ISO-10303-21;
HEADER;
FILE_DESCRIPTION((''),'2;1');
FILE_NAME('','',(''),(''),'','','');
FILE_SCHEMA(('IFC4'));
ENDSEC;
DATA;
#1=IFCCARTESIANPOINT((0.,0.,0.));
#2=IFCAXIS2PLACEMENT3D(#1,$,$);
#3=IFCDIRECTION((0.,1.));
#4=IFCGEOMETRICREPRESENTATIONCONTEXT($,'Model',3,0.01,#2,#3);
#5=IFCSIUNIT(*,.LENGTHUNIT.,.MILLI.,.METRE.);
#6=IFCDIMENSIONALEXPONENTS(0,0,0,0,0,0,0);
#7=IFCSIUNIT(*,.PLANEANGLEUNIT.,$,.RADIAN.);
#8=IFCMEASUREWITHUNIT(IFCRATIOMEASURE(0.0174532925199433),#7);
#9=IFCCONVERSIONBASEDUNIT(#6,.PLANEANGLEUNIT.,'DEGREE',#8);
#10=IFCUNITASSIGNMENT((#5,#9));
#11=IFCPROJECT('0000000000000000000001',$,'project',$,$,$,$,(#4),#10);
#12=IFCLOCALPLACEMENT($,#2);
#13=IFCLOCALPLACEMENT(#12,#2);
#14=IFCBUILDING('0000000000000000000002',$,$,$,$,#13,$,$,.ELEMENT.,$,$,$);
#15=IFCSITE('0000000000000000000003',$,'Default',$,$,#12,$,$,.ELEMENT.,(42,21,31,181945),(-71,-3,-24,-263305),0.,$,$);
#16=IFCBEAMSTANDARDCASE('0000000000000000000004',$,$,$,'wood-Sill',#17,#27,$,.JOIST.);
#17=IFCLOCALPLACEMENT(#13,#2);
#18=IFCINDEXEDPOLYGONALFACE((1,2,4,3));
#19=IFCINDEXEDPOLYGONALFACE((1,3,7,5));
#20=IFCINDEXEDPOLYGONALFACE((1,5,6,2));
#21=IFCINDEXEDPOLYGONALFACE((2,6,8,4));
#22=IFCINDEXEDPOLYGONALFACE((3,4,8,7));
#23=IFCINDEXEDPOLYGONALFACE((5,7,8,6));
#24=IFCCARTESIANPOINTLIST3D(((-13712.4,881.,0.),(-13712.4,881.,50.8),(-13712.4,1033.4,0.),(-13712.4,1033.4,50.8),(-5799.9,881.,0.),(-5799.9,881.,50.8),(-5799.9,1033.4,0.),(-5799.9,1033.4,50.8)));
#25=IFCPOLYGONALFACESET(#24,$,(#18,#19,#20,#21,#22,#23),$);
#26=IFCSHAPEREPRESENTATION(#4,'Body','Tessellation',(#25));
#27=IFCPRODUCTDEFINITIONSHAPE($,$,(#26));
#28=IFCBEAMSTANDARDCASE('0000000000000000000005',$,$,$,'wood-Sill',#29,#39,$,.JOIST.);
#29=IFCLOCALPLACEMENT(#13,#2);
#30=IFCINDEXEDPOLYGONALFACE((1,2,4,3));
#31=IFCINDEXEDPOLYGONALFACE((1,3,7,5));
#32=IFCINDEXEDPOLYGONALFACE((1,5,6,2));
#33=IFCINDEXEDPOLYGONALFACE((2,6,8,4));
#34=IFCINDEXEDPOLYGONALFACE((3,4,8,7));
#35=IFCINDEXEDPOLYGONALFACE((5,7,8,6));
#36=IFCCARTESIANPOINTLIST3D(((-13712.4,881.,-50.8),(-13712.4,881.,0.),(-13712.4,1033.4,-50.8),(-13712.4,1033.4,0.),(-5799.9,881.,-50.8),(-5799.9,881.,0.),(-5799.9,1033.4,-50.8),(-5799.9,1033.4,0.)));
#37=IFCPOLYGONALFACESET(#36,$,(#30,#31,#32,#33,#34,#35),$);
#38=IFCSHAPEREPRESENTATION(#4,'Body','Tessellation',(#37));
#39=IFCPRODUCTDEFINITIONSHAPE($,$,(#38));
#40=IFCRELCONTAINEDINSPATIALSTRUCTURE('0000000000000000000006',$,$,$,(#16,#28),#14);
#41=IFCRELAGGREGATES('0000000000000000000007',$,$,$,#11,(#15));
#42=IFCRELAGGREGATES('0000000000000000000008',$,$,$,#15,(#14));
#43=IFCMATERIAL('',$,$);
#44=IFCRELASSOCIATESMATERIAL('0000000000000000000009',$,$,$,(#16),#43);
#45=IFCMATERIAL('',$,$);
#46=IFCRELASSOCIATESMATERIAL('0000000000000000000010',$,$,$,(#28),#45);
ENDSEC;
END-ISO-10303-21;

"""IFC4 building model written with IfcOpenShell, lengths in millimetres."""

from ifc_helpers import new_model, entity, si_unit, converted_unit, direction, frame, origin, place, context, project, spatial, rectangle, extrude, material, element, save


model = new_model("IFC4")

# Units and contexts
model_context = context("Model", 3, precision=0.01, world=origin(), true_north=direction((0.0, 1.0)))
ifc_project = project(units=[si_unit("LENGTHUNIT", "METRE", prefix="MILLI"), converted_unit("PLANEANGLEUNIT", "DEGREE", entity("IfcRatioMeasure", 0.0174532925199433), si_unit("PLANEANGLEUNIT", "RADIAN"), dimensions=[0, 0, 0, 0, 0, 0, 0])], contexts=[model_context])

# Site, building
site_placement = place(None, origin())
site = spatial("IfcSite", under=ifc_project, at=site_placement, Name="Default", CompositionType="ELEMENT", RefLatitude=(42, 21, 31, 181945), RefLongitude=(-71, -3, -24, -263305), RefElevation=0.0)
building_placement = place(site_placement, origin())
building = spatial("IfcBuilding", under=site, at=building_placement, CompositionType="ELEMENT")

# Shared definitions
placement_1 = place(building_placement, origin())
placement_2 = place(placement_1, frame((-5799.9, 957.2, 0.0), z_axis=(0.0, 0.0, 1.0), x_axis=(-1.0, 0.0, 0.0)))

# Beams
ifc_material_1 = material(Name="")
beam_1_placement = place(placement_2, frame((3956.2, 0.0, 0.0), z_axis=(0.0, 0.0, 1.0), x_axis=(-1.0, 0.0, 0.0)))
element("IfcBeamStandardCase", 1, at=beam_1_placement, inside=building, material=ifc_material_1, ObjectType="wood-Sill", PredefinedType="JOIST", context=model_context, shape_type="SweptSolid", body=[
    extrude(rectangle(XDim=7912.5, YDim=152.4), origin(), (0.0, 0.0, 1.0), 50.8),
])
ifc_material_2 = material(Name="")
beam_2_placement = place(placement_2, frame((3956.2, 0.0, -50.8), z_axis=(0.0, 0.0, 1.0), x_axis=(-1.0, 0.0, 0.0)))
element("IfcBeamStandardCase", 2, at=beam_2_placement, inside=building, material=ifc_material_2, ObjectType="wood-Sill", PredefinedType="JOIST", context=model_context, shape_type="SweptSolid", body=[
    extrude(rectangle(XDim=7912.5, YDim=152.4), origin(), (0.0, 0.0, 1.0), 50.8),
])

save(model, "model.ifc")
